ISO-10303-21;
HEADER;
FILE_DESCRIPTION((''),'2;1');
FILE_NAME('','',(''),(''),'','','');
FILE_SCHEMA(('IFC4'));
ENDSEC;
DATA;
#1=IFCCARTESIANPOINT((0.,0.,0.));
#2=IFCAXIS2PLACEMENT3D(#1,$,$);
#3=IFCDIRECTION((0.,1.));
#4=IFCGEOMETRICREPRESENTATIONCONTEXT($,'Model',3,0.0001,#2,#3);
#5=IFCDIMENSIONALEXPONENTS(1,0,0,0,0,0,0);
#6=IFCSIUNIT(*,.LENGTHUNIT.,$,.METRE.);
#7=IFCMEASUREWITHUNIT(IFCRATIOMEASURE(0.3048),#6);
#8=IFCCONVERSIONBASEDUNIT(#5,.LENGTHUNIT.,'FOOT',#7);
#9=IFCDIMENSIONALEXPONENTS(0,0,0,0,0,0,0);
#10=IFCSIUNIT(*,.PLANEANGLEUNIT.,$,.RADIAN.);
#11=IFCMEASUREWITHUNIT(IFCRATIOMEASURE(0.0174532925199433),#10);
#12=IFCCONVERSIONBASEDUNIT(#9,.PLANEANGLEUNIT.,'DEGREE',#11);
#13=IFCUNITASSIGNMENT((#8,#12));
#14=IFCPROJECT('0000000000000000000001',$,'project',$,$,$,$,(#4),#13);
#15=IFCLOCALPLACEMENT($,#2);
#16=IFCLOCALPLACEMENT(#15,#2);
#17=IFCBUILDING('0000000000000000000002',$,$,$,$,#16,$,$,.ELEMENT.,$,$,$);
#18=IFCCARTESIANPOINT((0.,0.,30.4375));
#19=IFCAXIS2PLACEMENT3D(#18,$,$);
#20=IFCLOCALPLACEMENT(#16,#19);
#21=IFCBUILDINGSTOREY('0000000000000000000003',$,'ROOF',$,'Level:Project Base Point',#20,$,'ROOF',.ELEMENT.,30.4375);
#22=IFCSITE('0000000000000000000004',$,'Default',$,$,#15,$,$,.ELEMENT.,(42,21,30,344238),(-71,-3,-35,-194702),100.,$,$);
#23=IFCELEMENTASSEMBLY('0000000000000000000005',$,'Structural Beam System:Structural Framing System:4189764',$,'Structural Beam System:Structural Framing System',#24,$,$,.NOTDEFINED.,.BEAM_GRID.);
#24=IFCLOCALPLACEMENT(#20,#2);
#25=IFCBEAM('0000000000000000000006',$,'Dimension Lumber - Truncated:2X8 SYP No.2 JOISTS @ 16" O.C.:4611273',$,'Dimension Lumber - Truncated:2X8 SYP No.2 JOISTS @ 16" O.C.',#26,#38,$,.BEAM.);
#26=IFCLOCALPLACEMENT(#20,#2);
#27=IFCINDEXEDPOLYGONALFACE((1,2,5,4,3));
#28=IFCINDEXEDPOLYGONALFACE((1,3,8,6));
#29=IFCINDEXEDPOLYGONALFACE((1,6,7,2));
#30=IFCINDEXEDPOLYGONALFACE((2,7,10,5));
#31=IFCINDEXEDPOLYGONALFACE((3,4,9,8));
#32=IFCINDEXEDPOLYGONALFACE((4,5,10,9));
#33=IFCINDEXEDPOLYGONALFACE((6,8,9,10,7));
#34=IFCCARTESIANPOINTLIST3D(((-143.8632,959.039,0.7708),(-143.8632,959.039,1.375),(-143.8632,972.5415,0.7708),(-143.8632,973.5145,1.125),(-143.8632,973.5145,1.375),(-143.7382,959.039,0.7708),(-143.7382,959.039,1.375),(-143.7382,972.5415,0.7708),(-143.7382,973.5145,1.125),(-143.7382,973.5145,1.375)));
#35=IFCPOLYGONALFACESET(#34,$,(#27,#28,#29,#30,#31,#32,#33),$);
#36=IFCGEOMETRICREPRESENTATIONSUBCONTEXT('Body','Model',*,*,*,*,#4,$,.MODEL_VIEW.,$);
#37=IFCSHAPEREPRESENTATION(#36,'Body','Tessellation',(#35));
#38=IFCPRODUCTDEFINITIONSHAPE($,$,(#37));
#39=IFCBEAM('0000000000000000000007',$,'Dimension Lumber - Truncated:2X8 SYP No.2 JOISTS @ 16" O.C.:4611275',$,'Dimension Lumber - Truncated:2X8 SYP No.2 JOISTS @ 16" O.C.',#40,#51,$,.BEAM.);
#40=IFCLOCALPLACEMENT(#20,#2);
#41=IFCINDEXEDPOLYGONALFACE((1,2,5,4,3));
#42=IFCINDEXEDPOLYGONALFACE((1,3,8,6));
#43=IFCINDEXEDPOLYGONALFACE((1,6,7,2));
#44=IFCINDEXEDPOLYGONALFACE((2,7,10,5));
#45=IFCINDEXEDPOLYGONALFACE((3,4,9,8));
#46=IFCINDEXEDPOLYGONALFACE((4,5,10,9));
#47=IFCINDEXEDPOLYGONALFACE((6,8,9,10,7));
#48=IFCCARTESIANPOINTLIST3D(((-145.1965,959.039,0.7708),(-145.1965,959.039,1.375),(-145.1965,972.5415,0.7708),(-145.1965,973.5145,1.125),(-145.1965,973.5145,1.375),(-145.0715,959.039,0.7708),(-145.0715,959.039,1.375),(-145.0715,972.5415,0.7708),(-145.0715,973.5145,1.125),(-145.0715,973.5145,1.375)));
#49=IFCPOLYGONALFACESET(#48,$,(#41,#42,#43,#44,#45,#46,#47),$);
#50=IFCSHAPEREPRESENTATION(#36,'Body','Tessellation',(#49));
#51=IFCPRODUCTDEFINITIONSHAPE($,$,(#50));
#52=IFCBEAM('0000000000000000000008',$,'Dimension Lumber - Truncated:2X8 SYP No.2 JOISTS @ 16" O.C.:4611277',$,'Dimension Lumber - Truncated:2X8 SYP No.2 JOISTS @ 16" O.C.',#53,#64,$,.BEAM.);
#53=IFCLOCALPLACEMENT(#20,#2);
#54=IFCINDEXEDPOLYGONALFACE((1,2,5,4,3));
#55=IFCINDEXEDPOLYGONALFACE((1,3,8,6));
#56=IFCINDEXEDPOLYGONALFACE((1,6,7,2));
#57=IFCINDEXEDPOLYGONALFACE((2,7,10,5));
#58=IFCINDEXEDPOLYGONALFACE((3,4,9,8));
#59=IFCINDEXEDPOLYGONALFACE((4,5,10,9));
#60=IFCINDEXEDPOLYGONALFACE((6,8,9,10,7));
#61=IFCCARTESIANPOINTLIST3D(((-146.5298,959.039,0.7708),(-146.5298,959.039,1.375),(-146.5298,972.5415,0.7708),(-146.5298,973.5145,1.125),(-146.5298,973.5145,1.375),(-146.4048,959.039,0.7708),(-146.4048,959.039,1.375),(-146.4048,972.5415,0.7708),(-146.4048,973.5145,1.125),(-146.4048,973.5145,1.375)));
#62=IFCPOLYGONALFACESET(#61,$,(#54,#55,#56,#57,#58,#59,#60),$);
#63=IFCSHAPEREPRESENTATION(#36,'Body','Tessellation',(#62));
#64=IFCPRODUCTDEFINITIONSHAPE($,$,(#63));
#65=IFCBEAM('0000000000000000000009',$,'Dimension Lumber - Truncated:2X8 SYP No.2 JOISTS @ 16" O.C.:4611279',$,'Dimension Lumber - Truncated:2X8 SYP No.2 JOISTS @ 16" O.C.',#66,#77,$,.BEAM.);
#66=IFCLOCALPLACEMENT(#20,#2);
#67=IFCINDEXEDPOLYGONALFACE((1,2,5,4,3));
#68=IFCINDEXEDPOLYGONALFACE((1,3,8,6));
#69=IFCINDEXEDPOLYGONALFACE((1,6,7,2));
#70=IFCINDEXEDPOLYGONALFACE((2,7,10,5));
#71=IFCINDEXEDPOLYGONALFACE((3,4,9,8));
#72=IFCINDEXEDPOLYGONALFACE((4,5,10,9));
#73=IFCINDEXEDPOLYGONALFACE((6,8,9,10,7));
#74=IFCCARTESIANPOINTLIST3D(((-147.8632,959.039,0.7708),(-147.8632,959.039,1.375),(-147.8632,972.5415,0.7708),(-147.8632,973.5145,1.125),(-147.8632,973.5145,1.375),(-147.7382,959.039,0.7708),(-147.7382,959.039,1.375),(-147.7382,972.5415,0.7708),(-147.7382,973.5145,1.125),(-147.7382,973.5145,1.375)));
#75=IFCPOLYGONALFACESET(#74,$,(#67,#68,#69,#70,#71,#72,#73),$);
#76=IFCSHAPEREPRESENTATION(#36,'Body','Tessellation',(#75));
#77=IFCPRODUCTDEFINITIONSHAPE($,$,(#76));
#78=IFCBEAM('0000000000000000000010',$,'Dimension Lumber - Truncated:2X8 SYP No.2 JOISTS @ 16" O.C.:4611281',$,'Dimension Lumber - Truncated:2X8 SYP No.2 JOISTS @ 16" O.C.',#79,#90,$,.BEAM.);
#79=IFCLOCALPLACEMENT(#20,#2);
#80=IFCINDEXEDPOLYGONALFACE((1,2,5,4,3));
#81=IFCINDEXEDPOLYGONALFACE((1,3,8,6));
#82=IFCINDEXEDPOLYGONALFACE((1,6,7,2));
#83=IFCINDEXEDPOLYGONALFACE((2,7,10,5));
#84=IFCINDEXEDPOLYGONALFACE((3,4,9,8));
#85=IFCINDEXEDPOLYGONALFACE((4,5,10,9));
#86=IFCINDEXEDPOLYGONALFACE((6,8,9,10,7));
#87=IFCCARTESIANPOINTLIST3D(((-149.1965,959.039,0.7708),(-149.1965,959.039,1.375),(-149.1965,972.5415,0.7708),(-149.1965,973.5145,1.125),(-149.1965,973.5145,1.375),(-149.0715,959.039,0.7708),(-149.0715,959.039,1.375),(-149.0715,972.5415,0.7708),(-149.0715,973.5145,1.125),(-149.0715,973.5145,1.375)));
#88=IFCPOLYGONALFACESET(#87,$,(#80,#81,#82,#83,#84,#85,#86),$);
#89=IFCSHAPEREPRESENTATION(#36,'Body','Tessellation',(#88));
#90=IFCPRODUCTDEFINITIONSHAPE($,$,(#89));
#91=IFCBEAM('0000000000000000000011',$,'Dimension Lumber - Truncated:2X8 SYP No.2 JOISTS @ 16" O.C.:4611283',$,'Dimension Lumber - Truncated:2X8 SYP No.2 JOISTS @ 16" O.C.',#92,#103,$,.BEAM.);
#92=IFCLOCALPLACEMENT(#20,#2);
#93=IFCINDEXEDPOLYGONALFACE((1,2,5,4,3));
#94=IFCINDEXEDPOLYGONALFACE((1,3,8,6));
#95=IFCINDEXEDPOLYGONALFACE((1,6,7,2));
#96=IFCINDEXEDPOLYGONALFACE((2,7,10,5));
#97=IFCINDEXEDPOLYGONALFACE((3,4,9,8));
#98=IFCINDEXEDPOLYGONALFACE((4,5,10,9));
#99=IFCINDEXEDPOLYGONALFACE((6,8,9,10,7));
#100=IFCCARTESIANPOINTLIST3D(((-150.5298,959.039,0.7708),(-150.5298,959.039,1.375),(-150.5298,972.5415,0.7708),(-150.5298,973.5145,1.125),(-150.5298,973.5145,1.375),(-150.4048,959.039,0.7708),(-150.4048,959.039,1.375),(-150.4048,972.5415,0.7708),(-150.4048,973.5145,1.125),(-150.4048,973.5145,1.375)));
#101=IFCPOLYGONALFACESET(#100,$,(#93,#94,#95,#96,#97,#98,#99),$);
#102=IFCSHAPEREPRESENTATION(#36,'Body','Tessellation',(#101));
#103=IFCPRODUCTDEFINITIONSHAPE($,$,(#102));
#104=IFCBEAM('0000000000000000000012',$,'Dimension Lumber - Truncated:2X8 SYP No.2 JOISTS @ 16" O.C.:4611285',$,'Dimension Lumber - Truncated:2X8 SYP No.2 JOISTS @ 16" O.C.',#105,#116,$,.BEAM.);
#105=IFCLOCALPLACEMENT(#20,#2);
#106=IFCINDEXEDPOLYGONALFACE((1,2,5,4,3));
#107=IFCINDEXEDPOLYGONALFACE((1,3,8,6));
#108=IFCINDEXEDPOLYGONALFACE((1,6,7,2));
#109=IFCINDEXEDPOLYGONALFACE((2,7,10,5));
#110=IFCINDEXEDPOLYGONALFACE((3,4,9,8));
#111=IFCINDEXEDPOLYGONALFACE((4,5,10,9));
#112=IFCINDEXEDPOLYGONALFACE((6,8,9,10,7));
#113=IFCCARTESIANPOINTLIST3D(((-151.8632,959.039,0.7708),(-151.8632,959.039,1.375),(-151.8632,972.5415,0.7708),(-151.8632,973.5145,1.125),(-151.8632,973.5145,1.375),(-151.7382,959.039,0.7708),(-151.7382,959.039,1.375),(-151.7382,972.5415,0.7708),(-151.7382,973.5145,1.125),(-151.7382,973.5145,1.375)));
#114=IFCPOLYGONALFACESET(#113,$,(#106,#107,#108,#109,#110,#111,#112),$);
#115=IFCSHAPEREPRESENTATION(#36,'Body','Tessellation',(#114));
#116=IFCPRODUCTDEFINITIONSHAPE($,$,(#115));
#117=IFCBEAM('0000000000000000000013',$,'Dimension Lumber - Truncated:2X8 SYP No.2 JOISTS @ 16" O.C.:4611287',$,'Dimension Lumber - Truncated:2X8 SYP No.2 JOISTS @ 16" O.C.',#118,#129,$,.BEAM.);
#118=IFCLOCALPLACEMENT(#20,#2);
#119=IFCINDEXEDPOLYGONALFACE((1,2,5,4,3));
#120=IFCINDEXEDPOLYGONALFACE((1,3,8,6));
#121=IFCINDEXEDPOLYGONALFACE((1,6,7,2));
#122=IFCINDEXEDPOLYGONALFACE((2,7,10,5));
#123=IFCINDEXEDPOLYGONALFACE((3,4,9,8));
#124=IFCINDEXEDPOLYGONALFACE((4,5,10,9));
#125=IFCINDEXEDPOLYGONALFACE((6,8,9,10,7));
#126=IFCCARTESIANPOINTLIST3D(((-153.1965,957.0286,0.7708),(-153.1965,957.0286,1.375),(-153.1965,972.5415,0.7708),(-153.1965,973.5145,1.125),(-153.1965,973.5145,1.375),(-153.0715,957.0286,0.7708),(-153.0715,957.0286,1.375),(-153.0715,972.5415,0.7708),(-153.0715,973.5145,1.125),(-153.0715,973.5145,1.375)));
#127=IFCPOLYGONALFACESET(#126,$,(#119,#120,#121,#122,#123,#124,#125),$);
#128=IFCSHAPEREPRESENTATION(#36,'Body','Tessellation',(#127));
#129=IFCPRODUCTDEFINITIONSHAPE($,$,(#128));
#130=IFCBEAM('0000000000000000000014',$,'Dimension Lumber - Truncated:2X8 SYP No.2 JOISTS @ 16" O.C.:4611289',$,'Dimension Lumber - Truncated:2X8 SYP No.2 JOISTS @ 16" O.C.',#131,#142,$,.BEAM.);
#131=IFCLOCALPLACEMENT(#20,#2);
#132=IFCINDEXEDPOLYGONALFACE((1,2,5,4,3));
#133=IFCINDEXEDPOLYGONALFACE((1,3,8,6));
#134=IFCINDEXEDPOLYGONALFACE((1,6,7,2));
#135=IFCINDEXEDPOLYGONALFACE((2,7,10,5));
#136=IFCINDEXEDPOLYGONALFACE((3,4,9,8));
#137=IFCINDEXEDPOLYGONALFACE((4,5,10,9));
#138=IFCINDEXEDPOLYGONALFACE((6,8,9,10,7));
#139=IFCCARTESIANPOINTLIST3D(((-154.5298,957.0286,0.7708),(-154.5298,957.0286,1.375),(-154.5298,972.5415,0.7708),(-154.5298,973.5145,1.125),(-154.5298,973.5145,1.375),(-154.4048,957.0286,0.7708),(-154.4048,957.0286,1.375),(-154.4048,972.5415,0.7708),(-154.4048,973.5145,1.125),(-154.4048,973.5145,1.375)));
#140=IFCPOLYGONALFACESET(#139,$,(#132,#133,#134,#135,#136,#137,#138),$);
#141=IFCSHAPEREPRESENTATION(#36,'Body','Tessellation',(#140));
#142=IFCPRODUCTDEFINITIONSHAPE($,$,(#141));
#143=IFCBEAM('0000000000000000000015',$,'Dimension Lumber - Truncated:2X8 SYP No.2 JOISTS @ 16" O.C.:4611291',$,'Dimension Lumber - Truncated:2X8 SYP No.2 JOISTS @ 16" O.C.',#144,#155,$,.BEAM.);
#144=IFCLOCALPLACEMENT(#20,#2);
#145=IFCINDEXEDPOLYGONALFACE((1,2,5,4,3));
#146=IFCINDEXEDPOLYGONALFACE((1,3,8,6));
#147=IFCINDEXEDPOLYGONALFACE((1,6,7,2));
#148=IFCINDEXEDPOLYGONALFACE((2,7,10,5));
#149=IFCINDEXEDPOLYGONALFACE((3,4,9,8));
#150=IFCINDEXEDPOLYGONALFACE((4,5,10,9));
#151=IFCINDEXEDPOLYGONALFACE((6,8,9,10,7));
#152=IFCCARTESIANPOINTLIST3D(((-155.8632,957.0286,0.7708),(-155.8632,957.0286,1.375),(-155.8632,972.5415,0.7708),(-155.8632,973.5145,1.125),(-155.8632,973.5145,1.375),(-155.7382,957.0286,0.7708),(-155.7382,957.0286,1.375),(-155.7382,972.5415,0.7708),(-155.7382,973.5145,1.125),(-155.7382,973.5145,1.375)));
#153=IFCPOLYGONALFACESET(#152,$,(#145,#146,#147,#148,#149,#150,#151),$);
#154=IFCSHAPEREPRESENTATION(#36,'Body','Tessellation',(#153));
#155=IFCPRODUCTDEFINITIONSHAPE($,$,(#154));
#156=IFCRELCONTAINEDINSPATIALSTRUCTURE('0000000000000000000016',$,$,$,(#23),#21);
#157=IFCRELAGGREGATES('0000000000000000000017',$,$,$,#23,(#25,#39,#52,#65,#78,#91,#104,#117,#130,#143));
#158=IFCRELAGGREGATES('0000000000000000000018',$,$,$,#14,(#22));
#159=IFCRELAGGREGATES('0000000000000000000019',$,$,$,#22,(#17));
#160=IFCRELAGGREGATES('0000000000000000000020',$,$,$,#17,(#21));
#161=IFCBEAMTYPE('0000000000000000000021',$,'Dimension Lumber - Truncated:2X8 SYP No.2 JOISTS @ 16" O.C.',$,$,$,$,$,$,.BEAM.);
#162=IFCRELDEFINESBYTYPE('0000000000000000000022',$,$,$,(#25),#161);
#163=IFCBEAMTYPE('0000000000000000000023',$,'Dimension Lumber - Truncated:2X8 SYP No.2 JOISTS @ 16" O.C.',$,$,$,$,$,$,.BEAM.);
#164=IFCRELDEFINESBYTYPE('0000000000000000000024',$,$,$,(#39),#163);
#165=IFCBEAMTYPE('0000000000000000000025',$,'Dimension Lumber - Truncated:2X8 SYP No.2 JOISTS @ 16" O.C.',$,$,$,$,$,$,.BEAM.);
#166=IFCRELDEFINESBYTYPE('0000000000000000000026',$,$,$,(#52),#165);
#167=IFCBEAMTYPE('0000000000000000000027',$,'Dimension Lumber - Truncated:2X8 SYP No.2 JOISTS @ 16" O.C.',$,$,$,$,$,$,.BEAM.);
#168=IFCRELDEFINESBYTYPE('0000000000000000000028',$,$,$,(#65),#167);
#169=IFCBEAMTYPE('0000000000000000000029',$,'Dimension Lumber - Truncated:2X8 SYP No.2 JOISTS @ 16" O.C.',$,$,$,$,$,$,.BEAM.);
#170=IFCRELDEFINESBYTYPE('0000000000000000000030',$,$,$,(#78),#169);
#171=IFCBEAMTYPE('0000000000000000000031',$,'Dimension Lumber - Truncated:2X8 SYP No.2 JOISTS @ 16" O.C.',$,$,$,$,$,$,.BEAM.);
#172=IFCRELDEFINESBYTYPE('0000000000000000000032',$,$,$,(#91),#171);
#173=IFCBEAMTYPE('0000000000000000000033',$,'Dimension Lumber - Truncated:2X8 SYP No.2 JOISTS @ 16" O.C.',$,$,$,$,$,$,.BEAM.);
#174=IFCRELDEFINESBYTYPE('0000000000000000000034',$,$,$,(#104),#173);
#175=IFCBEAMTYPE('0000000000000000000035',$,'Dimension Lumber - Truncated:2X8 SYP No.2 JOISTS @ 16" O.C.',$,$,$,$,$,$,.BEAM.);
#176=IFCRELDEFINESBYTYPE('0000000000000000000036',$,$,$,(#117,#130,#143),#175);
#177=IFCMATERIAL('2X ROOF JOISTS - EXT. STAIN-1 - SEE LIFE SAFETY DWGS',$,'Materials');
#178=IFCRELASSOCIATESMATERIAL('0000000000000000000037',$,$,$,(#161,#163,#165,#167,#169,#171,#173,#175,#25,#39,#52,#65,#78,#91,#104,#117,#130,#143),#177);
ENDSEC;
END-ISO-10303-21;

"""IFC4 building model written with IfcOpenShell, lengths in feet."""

from ifc_helpers import new_model, entity, si_unit, converted_unit, direction, frame, frame_2d, origin, place, context, subcontext, project, spatial, rectangle, extrude, clip, halfspace, source, transform, mapped, material, material_profile, profile_set, profile_usage, type_object, type_shapes, element, aggregate, save


model = new_model("IFC4")

# Units and contexts
model_context = context("Model", 3, precision=0.0001, world=origin(), true_north=direction((0.0, 1.0)))
body_context = subcontext(model_context, "Body", "Model", "MODEL_VIEW")
ifc_project = project(units=[converted_unit("LENGTHUNIT", "FOOT", entity("IfcRatioMeasure", 0.3048), si_unit("LENGTHUNIT", "METRE"), dimensions=[1, 0, 0, 0, 0, 0, 0]), converted_unit("PLANEANGLEUNIT", "DEGREE", entity("IfcRatioMeasure", 0.0174532925199433), si_unit("PLANEANGLEUNIT", "RADIAN"), dimensions=[0, 0, 0, 0, 0, 0, 0])], contexts=[model_context])

# Site, building, storey
site_placement = place(None, origin())
site = spatial("IfcSite", under=ifc_project, at=site_placement, Name="Default", CompositionType="ELEMENT", RefLatitude=(42, 21, 30, 344238), RefLongitude=(-71, -3, -35, -194702), RefElevation=100.0)
building_placement = place(site_placement, origin())
building = spatial("IfcBuilding", under=site, at=building_placement, CompositionType="ELEMENT")
storey_placement = place(building_placement, frame((0.0, 0.0, 30.4375)))
storey = spatial("IfcBuildingStorey", under=building, at=storey_placement, Name="ROOF", ObjectType="Level:Project Base Point", LongName="ROOF", CompositionType="ELEMENT", Elevation=30.4375)

# Element assembly, beams
assembly_1_placement = place(storey_placement, origin())
assembly_1 = element("IfcElementAssembly", 1, at=assembly_1_placement, inside=storey, Name="Structural Beam System:Structural Framing System:4189764", ObjectType="Structural Beam System:Structural Framing System", AssemblyPlace="NOTDEFINED", PredefinedType="BEAM_GRID")
ifc_material_1 = material(Name="2X ROOF JOISTS - EXT. STAIN-1 - SEE LIFE SAFETY DWGS", Category="Materials")
ifc_material_profile_1 = material_profile(ifc_material_1, rectangle(XDim=0.6042, YDim=0.125, at=frame_2d((0.0, 0.0), x_axis=(0.0, 1.0))), Name="2X8 SYP No.2 JOISTS @ 16\" O.C.")
ifc_profile_set_1 = profile_set([ifc_material_profile_1], Name="2X8 SYP No.2 JOISTS @ 16\" O.C.")
ifc_profile_usage_1 = profile_usage(ifc_profile_set_1, cardinal=8)
beam_type_1 = type_object("IfcBeamType", Name="Dimension Lumber - Truncated:2X8 SYP No.2 JOISTS @ 16\" O.C.", PredefinedType="BEAM", material=ifc_profile_set_1)
shared_shape_1 = source(origin(), body_context, "Body", "Clipping", [
    clip(extrude(rectangle(XDim=0.6042, YDim=0.125, at=frame_2d((0.0, 0.0), x_axis=(0.0, 1.0))), frame((-7.2378, 0.0, 0.0), z_axis=(1.0, 0.0, 0.0), x_axis=(0.0, 1.0, 0.0)), (0.0, 0.0, 1.0), 14.4755), halfspace(frame((-6.2647, -0.0625, -0.3021), z_axis=(-0.34202, 0.0, -0.939693), x_axis=(0.0, 1.0, 0.0)), False)),
])
type_shapes(beam_type_1, [shared_shape_1])
beam_1_placement = place(assembly_1_placement, frame((-143.8007, 966.2768, 1.0729), z_axis=(0.0, 0.0, 1.0), x_axis=(0.0, -1.0, 0.0)))
beam_1 = element("IfcBeam", 2, at=beam_1_placement, type_object=beam_type_1, material=ifc_profile_usage_1, Name="Dimension Lumber - Truncated:2X8 SYP No.2 JOISTS @ 16\" O.C.:4611273", ObjectType="Dimension Lumber - Truncated:2X8 SYP No.2 JOISTS @ 16\" O.C.", PredefinedType="BEAM", context=body_context, shape_type="MappedRepresentation", body=[
    mapped(shared_shape_1, transform((0.0, 0.0, 0.0), scale=1.0)),
])
ifc_profile_usage_2 = profile_usage(ifc_profile_set_1, cardinal=8)
beam_type_2 = type_object("IfcBeamType", Name="Dimension Lumber - Truncated:2X8 SYP No.2 JOISTS @ 16\" O.C.", PredefinedType="BEAM", material=ifc_profile_set_1)
shared_shape_2 = source(origin(), body_context, "Body", "Clipping", [
    clip(extrude(rectangle(XDim=0.6042, YDim=0.125, at=frame_2d((0.0, 0.0), x_axis=(0.0, 1.0))), frame((-7.2378, 0.0, 0.0), z_axis=(1.0, 0.0, 0.0), x_axis=(0.0, 1.0, 0.0)), (0.0, 0.0, 1.0), 14.4755), halfspace(frame((-6.2647, -0.0625, -0.3021), z_axis=(-0.34202, 0.0, -0.939693), x_axis=(0.0, 1.0, 0.0)), False)),
])
type_shapes(beam_type_2, [shared_shape_2])
beam_2_placement = place(assembly_1_placement, frame((-145.134, 966.2768, 1.0729), z_axis=(0.0, 0.0, 1.0), x_axis=(0.0, -1.0, 0.0)))
beam_2 = element("IfcBeam", 3, at=beam_2_placement, type_object=beam_type_2, material=ifc_profile_usage_2, Name="Dimension Lumber - Truncated:2X8 SYP No.2 JOISTS @ 16\" O.C.:4611275", ObjectType="Dimension Lumber - Truncated:2X8 SYP No.2 JOISTS @ 16\" O.C.", PredefinedType="BEAM", context=body_context, shape_type="MappedRepresentation", body=[
    mapped(shared_shape_2, transform((0.0, 0.0, 0.0), scale=1.0)),
])
ifc_profile_usage_3 = profile_usage(ifc_profile_set_1, cardinal=8)
beam_type_3 = type_object("IfcBeamType", Name="Dimension Lumber - Truncated:2X8 SYP No.2 JOISTS @ 16\" O.C.", PredefinedType="BEAM", material=ifc_profile_set_1)
shared_shape_3 = source(origin(), body_context, "Body", "Clipping", [
    clip(extrude(rectangle(XDim=0.6042, YDim=0.125, at=frame_2d((0.0, 0.0), x_axis=(0.0, 1.0))), frame((-7.2378, 0.0, 0.0), z_axis=(1.0, 0.0, 0.0), x_axis=(0.0, 1.0, 0.0)), (0.0, 0.0, 1.0), 14.4755), halfspace(frame((-6.2647, -0.0625, -0.3021), z_axis=(-0.34202, 0.0, -0.939693), x_axis=(0.0, 1.0, 0.0)), False)),
])
type_shapes(beam_type_3, [shared_shape_3])
beam_3_placement = place(assembly_1_placement, frame((-146.4673, 966.2768, 1.0729), z_axis=(0.0, 0.0, 1.0), x_axis=(0.0, -1.0, 0.0)))
beam_3 = element("IfcBeam", 4, at=beam_3_placement, type_object=beam_type_3, material=ifc_profile_usage_3, Name="Dimension Lumber - Truncated:2X8 SYP No.2 JOISTS @ 16\" O.C.:4611277", ObjectType="Dimension Lumber - Truncated:2X8 SYP No.2 JOISTS @ 16\" O.C.", PredefinedType="BEAM", context=body_context, shape_type="MappedRepresentation", body=[
    mapped(shared_shape_3, transform((0.0, 0.0, 0.0), scale=1.0)),
])
ifc_profile_usage_4 = profile_usage(ifc_profile_set_1, cardinal=8)
beam_type_4 = type_object("IfcBeamType", Name="Dimension Lumber - Truncated:2X8 SYP No.2 JOISTS @ 16\" O.C.", PredefinedType="BEAM", material=ifc_profile_set_1)
shared_shape_4 = source(origin(), body_context, "Body", "Clipping", [
    clip(extrude(rectangle(XDim=0.6042, YDim=0.125, at=frame_2d((0.0, 0.0), x_axis=(0.0, 1.0))), frame((-7.2378, 0.0, 0.0), z_axis=(1.0, 0.0, 0.0), x_axis=(0.0, 1.0, 0.0)), (0.0, 0.0, 1.0), 14.4755), halfspace(frame((-6.2647, -0.0625, -0.3021), z_axis=(-0.34202, 0.0, -0.939693), x_axis=(0.0, 1.0, 0.0)), False)),
])
type_shapes(beam_type_4, [shared_shape_4])
beam_4_placement = place(assembly_1_placement, frame((-147.8007, 966.2768, 1.0729), z_axis=(0.0, 0.0, 1.0), x_axis=(0.0, -1.0, 0.0)))
beam_4 = element("IfcBeam", 5, at=beam_4_placement, type_object=beam_type_4, material=ifc_profile_usage_4, Name="Dimension Lumber - Truncated:2X8 SYP No.2 JOISTS @ 16\" O.C.:4611279", ObjectType="Dimension Lumber - Truncated:2X8 SYP No.2 JOISTS @ 16\" O.C.", PredefinedType="BEAM", context=body_context, shape_type="MappedRepresentation", body=[
    mapped(shared_shape_4, transform((0.0, 0.0, 0.0), scale=1.0)),
])
ifc_profile_usage_5 = profile_usage(ifc_profile_set_1, cardinal=8)
beam_type_5 = type_object("IfcBeamType", Name="Dimension Lumber - Truncated:2X8 SYP No.2 JOISTS @ 16\" O.C.", PredefinedType="BEAM", material=ifc_profile_set_1)
shared_shape_5 = source(origin(), body_context, "Body", "Clipping", [
    clip(extrude(rectangle(XDim=0.6042, YDim=0.125, at=frame_2d((0.0, 0.0), x_axis=(0.0, 1.0))), frame((-7.2378, 0.0, 0.0), z_axis=(1.0, 0.0, 0.0), x_axis=(0.0, 1.0, 0.0)), (0.0, 0.0, 1.0), 14.4755), halfspace(frame((-6.2647, -0.0625, -0.3021), z_axis=(-0.34202, 0.0, -0.939693), x_axis=(0.0, 1.0, 0.0)), False)),
])
type_shapes(beam_type_5, [shared_shape_5])
beam_5_placement = place(assembly_1_placement, frame((-149.134, 966.2768, 1.0729), z_axis=(0.0, 0.0, 1.0), x_axis=(0.0, -1.0, 0.0)))
beam_5 = element("IfcBeam", 6, at=beam_5_placement, type_object=beam_type_5, material=ifc_profile_usage_5, Name="Dimension Lumber - Truncated:2X8 SYP No.2 JOISTS @ 16\" O.C.:4611281", ObjectType="Dimension Lumber - Truncated:2X8 SYP No.2 JOISTS @ 16\" O.C.", PredefinedType="BEAM", context=body_context, shape_type="MappedRepresentation", body=[
    mapped(shared_shape_5, transform((0.0, 0.0, 0.0), scale=1.0)),
])
ifc_profile_usage_6 = profile_usage(ifc_profile_set_1, cardinal=8)
beam_type_6 = type_object("IfcBeamType", Name="Dimension Lumber - Truncated:2X8 SYP No.2 JOISTS @ 16\" O.C.", PredefinedType="BEAM", material=ifc_profile_set_1)
shared_shape_6 = source(origin(), body_context, "Body", "Clipping", [
    clip(extrude(rectangle(XDim=0.6042, YDim=0.125, at=frame_2d((0.0, 0.0), x_axis=(0.0, 1.0))), frame((-7.2378, 0.0, 0.0), z_axis=(1.0, 0.0, 0.0), x_axis=(0.0, 1.0, 0.0)), (0.0, 0.0, 1.0), 14.4755), halfspace(frame((-6.2647, -0.0625, -0.3021), z_axis=(-0.34202, 0.0, -0.939693), x_axis=(0.0, 1.0, 0.0)), False)),
])
type_shapes(beam_type_6, [shared_shape_6])
beam_6_placement = place(assembly_1_placement, frame((-150.4673, 966.2768, 1.0729), z_axis=(0.0, 0.0, 1.0), x_axis=(0.0, -1.0, 0.0)))
beam_6 = element("IfcBeam", 7, at=beam_6_placement, type_object=beam_type_6, material=ifc_profile_usage_6, Name="Dimension Lumber - Truncated:2X8 SYP No.2 JOISTS @ 16\" O.C.:4611283", ObjectType="Dimension Lumber - Truncated:2X8 SYP No.2 JOISTS @ 16\" O.C.", PredefinedType="BEAM", context=body_context, shape_type="MappedRepresentation", body=[
    mapped(shared_shape_6, transform((0.0, 0.0, 0.0), scale=1.0)),
])
ifc_profile_usage_7 = profile_usage(ifc_profile_set_1, cardinal=8)
beam_type_7 = type_object("IfcBeamType", Name="Dimension Lumber - Truncated:2X8 SYP No.2 JOISTS @ 16\" O.C.", PredefinedType="BEAM", material=ifc_profile_set_1)
shared_shape_7 = source(origin(), body_context, "Body", "Clipping", [
    clip(extrude(rectangle(XDim=0.6042, YDim=0.125, at=frame_2d((0.0, 0.0), x_axis=(0.0, 1.0))), frame((-7.2378, 0.0, 0.0), z_axis=(1.0, 0.0, 0.0), x_axis=(0.0, 1.0, 0.0)), (0.0, 0.0, 1.0), 14.4755), halfspace(frame((-6.2647, -0.0625, -0.3021), z_axis=(-0.34202, 0.0, -0.939693), x_axis=(0.0, 1.0, 0.0)), False)),
])
type_shapes(beam_type_7, [shared_shape_7])
beam_7_placement = place(assembly_1_placement, frame((-151.8007, 966.2768, 1.0729), z_axis=(0.0, 0.0, 1.0), x_axis=(0.0, -1.0, 0.0)))
beam_7 = element("IfcBeam", 8, at=beam_7_placement, type_object=beam_type_7, material=ifc_profile_usage_7, Name="Dimension Lumber - Truncated:2X8 SYP No.2 JOISTS @ 16\" O.C.:4611285", ObjectType="Dimension Lumber - Truncated:2X8 SYP No.2 JOISTS @ 16\" O.C.", PredefinedType="BEAM", context=body_context, shape_type="MappedRepresentation", body=[
    mapped(shared_shape_7, transform((0.0, 0.0, 0.0), scale=1.0)),
])
ifc_profile_usage_8 = profile_usage(ifc_profile_set_1, cardinal=8)
beam_type_8 = type_object("IfcBeamType", Name="Dimension Lumber - Truncated:2X8 SYP No.2 JOISTS @ 16\" O.C.", PredefinedType="BEAM", material=ifc_profile_set_1)
shared_shape_8 = source(origin(), body_context, "Body", "Clipping", [
    clip(extrude(rectangle(XDim=0.6042, YDim=0.125, at=frame_2d((0.0, 0.0), x_axis=(0.0, 1.0))), frame((-8.243, 0.0, 0.0), z_axis=(1.0, 0.0, 0.0), x_axis=(0.0, 1.0, 0.0)), (0.0, 0.0, 1.0), 16.4859), halfspace(frame((-7.2699, -0.0625, -0.3021), z_axis=(-0.34202, 0.0, -0.939693), x_axis=(0.0, 1.0, 0.0)), False)),
])
type_shapes(beam_type_8, [shared_shape_8])
beam_8_placement = place(assembly_1_placement, frame((-153.134, 965.2716, 1.0729), z_axis=(0.0, 0.0, 1.0), x_axis=(0.0, -1.0, 0.0)))
beam_8 = element("IfcBeam", 9, at=beam_8_placement, type_object=beam_type_8, material=ifc_profile_usage_8, Name="Dimension Lumber - Truncated:2X8 SYP No.2 JOISTS @ 16\" O.C.:4611287", ObjectType="Dimension Lumber - Truncated:2X8 SYP No.2 JOISTS @ 16\" O.C.", PredefinedType="BEAM", context=body_context, shape_type="MappedRepresentation", body=[
    mapped(shared_shape_8, transform((0.0, 0.0, 0.0), scale=1.0)),
])
ifc_profile_usage_9 = profile_usage(ifc_profile_set_1, cardinal=8)
beam_9_placement = place(assembly_1_placement, frame((-154.4673, 965.2716, 1.0729), z_axis=(0.0, 0.0, 1.0), x_axis=(0.0, -1.0, 0.0)))
beam_9 = element("IfcBeam", 10, at=beam_9_placement, type_object=beam_type_8, material=ifc_profile_usage_9, Name="Dimension Lumber - Truncated:2X8 SYP No.2 JOISTS @ 16\" O.C.:4611289", ObjectType="Dimension Lumber - Truncated:2X8 SYP No.2 JOISTS @ 16\" O.C.", PredefinedType="BEAM", context=body_context, shape_type="MappedRepresentation", body=[
    mapped(shared_shape_8, transform((0.0, 0.0, 0.0), scale=1.0)),
])
ifc_profile_usage_10 = profile_usage(ifc_profile_set_1, cardinal=8)
beam_10_placement = place(assembly_1_placement, frame((-155.8007, 965.2716, 1.0729), z_axis=(0.0, 0.0, 1.0), x_axis=(0.0, -1.0, 0.0)))
beam_10 = element("IfcBeam", 11, at=beam_10_placement, type_object=beam_type_8, material=ifc_profile_usage_10, Name="Dimension Lumber - Truncated:2X8 SYP No.2 JOISTS @ 16\" O.C.:4611291", ObjectType="Dimension Lumber - Truncated:2X8 SYP No.2 JOISTS @ 16\" O.C.", PredefinedType="BEAM", context=body_context, shape_type="MappedRepresentation", body=[
    mapped(shared_shape_8, transform((0.0, 0.0, 0.0), scale=1.0)),
])
aggregate(assembly_1, [beam_1, beam_2, beam_3, beam_4, beam_5, beam_6, beam_7, beam_8, beam_9, beam_10])

save(model, "model.ifc")
